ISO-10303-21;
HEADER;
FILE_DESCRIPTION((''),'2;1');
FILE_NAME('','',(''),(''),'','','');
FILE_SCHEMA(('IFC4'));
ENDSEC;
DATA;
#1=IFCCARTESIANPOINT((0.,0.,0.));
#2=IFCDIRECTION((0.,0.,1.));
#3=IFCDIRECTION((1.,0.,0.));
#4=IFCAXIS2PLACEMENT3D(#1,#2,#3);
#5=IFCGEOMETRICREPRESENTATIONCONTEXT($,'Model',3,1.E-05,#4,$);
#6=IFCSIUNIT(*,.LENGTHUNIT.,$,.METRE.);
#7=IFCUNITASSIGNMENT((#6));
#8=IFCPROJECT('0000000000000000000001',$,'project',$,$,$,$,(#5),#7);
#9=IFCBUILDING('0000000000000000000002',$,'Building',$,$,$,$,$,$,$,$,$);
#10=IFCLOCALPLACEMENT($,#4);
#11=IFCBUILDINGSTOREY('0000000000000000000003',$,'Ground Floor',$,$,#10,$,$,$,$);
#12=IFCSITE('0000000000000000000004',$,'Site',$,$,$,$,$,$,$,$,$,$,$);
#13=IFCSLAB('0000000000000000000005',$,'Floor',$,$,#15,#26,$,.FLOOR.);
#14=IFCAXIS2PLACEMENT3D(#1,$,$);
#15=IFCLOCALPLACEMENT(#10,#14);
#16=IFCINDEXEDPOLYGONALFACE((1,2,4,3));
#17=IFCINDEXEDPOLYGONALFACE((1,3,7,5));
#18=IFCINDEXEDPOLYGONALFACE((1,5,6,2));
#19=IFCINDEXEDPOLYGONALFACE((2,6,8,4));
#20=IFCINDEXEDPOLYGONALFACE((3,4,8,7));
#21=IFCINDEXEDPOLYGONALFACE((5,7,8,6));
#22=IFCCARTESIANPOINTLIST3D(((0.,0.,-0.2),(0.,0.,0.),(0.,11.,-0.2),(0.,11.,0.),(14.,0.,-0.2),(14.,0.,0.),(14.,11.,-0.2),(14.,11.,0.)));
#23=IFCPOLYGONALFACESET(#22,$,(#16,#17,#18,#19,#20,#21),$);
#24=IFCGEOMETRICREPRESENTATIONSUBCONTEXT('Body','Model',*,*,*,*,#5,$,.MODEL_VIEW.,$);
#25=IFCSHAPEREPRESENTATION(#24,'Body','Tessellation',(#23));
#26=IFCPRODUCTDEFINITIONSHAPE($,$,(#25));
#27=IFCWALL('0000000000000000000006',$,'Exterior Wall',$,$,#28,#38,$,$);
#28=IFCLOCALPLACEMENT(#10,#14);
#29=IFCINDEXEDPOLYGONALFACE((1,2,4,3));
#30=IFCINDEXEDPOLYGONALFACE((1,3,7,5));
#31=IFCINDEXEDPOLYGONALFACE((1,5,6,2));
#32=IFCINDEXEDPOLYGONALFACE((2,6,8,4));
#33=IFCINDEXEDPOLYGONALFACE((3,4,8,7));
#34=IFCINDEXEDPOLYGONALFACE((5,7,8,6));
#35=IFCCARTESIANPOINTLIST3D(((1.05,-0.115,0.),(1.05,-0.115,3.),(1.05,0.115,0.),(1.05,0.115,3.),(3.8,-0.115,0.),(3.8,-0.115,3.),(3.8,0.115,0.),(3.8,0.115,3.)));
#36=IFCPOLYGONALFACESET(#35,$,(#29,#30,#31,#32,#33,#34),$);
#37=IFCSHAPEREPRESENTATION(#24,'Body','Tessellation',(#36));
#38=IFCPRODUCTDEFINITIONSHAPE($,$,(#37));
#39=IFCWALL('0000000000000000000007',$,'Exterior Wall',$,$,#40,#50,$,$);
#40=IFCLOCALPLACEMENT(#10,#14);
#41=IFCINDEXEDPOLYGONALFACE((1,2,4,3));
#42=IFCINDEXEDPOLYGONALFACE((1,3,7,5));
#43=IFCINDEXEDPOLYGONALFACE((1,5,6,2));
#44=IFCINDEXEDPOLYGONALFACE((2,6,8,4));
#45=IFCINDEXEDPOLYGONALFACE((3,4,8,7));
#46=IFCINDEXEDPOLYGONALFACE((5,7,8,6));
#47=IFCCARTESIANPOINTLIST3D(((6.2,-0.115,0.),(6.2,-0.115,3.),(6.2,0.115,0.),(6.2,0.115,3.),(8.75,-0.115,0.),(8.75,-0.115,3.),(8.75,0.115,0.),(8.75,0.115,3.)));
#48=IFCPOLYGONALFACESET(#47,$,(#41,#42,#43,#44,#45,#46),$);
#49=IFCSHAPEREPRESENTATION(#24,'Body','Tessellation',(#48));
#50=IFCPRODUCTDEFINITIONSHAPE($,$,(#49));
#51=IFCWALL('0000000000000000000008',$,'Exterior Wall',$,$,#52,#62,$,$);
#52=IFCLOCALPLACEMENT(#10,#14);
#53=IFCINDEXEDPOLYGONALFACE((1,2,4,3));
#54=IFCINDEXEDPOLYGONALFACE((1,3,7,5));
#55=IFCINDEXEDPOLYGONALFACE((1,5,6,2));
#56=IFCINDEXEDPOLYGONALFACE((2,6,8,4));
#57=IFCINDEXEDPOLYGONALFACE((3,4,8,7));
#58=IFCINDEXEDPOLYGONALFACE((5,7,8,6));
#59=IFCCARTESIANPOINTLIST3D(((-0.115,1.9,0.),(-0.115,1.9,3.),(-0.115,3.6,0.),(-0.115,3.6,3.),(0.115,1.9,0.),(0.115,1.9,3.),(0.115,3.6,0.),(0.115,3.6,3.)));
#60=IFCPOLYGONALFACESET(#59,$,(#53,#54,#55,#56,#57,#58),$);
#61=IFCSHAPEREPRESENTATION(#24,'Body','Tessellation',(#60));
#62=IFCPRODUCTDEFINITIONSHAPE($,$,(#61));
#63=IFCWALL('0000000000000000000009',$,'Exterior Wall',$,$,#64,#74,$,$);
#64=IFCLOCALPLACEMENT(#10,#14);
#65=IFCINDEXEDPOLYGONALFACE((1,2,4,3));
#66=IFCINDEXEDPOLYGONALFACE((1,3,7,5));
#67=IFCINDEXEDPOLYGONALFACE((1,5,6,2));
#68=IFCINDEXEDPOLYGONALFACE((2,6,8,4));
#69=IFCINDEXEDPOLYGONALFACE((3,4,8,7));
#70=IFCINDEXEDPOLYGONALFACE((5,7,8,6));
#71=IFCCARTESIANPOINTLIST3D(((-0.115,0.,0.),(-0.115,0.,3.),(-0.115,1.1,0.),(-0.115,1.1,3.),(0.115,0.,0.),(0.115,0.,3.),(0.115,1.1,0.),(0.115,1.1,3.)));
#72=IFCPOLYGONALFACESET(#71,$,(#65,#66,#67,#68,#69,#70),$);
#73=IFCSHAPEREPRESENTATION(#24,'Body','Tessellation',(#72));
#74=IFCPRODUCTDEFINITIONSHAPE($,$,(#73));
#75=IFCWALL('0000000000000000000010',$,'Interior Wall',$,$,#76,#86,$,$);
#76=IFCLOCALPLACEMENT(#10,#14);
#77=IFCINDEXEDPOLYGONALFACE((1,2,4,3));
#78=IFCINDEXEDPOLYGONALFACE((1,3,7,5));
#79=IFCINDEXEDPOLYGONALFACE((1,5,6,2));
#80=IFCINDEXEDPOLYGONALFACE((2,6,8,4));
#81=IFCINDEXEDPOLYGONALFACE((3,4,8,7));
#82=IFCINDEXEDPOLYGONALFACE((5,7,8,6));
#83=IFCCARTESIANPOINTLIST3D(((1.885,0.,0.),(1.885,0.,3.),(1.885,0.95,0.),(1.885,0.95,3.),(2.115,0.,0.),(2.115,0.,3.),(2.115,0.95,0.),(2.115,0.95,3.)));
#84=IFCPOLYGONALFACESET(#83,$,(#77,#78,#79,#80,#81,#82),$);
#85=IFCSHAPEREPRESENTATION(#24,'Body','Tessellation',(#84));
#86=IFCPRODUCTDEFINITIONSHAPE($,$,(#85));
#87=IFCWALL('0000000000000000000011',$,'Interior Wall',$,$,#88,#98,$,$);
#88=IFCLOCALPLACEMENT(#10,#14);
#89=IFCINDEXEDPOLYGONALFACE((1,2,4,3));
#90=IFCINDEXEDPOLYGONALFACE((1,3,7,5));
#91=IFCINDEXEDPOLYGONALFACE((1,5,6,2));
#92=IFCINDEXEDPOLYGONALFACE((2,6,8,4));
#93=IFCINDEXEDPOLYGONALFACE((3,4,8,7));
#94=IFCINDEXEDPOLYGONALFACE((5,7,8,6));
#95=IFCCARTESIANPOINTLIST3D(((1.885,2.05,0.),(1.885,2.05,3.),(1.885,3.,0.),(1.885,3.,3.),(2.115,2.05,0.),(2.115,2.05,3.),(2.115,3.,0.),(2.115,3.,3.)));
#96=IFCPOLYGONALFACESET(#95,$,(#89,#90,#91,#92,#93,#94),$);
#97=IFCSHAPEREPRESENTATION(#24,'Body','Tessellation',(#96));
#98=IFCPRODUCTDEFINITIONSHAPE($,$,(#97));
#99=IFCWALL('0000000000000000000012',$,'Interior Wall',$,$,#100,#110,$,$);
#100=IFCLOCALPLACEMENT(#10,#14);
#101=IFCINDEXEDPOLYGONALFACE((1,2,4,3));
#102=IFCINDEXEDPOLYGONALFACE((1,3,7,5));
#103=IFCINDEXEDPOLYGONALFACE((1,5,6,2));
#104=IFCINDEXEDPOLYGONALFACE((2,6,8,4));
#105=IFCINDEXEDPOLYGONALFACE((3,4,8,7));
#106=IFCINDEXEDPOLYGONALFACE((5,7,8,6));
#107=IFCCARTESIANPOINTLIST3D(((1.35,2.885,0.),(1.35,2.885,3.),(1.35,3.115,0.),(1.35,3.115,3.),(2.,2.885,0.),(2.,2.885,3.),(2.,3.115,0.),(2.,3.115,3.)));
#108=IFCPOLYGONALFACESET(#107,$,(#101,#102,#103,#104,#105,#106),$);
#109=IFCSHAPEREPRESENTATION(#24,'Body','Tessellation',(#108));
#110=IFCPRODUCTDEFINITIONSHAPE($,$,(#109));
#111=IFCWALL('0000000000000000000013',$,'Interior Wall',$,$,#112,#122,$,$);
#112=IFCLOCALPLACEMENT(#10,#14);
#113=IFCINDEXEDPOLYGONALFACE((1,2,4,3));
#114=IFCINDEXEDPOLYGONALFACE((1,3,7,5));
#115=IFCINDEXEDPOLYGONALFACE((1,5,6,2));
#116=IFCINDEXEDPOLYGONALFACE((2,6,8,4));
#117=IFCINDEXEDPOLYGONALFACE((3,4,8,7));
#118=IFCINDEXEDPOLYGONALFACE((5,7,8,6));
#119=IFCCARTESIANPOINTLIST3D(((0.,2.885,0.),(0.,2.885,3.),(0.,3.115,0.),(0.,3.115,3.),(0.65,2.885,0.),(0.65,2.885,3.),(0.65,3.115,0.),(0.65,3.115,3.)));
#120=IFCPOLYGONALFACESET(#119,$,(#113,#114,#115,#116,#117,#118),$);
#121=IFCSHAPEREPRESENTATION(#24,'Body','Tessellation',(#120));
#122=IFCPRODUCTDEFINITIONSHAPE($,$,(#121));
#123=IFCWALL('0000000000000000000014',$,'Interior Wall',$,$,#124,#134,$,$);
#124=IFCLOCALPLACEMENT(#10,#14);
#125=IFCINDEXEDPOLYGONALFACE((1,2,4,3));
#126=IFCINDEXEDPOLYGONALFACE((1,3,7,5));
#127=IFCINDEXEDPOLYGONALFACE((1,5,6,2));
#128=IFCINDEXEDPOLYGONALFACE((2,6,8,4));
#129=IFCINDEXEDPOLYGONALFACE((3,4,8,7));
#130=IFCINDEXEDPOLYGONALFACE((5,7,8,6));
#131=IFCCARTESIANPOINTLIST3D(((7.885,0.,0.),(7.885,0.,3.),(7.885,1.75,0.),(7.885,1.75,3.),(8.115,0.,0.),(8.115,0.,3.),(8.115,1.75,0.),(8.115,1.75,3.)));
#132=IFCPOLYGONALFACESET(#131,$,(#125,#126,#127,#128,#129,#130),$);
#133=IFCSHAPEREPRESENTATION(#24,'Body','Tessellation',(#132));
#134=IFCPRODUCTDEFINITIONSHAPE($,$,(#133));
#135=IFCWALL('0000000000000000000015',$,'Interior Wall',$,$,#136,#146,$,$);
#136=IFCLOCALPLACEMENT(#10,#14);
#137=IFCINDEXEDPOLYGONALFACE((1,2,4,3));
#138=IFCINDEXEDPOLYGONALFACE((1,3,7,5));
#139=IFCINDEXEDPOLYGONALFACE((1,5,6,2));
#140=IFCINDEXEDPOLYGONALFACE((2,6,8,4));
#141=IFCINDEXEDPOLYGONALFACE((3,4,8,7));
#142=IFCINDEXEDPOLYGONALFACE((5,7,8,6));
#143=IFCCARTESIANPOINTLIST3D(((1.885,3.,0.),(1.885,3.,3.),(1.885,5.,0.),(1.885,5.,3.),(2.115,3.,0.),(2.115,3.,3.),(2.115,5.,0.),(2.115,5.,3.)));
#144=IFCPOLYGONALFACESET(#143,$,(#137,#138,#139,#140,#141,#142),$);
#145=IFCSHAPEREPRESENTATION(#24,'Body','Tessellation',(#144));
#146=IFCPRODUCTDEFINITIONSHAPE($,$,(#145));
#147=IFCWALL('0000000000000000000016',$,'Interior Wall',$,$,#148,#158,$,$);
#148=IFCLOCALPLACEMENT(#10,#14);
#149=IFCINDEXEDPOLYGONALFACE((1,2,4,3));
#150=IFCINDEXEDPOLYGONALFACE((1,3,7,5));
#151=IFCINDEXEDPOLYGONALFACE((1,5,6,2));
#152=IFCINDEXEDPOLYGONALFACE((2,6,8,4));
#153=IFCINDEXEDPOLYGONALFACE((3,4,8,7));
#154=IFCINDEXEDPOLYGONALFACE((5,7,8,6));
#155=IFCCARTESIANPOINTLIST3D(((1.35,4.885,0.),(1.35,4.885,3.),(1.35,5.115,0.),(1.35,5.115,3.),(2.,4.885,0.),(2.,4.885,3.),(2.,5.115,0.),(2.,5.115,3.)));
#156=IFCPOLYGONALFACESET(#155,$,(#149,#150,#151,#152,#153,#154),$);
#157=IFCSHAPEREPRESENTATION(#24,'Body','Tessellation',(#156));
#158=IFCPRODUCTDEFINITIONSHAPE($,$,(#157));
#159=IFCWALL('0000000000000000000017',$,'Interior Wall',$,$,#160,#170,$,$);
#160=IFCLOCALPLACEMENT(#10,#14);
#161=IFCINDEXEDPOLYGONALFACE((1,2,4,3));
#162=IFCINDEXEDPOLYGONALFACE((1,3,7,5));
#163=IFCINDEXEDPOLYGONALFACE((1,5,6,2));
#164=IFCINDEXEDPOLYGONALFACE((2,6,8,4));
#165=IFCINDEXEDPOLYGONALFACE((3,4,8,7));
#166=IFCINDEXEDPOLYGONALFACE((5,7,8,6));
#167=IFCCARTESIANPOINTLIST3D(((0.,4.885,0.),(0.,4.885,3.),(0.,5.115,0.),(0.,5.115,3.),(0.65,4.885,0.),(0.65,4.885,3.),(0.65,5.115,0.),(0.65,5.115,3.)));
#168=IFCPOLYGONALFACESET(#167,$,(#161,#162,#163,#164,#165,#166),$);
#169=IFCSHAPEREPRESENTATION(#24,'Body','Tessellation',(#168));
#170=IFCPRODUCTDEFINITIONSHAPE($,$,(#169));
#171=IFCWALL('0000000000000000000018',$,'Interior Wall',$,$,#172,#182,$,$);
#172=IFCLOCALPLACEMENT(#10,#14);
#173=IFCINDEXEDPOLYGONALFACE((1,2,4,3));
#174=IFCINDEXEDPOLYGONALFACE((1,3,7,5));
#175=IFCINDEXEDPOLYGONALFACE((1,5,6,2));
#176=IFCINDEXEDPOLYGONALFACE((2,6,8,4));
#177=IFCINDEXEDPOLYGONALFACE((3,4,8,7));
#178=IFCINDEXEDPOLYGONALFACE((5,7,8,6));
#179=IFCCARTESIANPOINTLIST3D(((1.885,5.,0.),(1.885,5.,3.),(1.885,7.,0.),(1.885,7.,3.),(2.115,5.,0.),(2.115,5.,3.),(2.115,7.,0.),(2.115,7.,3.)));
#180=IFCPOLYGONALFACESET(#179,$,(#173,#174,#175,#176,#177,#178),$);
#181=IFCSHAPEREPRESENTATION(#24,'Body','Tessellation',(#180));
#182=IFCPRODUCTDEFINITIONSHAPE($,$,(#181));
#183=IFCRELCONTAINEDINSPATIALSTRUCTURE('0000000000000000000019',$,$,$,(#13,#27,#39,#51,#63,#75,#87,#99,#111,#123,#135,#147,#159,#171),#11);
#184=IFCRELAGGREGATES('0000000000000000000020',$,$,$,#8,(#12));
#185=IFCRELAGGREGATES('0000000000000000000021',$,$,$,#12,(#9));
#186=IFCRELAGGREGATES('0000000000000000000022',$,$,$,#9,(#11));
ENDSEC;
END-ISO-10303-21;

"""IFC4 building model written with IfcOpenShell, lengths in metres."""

from ifc_helpers import new_model, si_unit, frame, origin_with_axes, place, context, subcontext, project, spatial, indexed_curve, outline, extrude, element, save


model = new_model("IFC4")

# Units and contexts
model_context = context("Model", 3, precision=1e-05, world=origin_with_axes())
body_context = subcontext(model_context, "Body", "Model", "MODEL_VIEW")
ifc_project = project(units=[si_unit("LENGTHUNIT", "METRE")], contexts=[model_context])

# Site, building, storey
site = spatial("IfcSite", under=ifc_project, Name="Site")
building = spatial("IfcBuilding", under=site, Name="Building")
storey_placement = place(None, origin_with_axes())
storey = spatial("IfcBuildingStorey", under=building, at=storey_placement, Name="Ground Floor")

# Slab
slab_placement = place(storey_placement, frame((0.0, 0.0, -0.2), z_axis=(0.0, 0.0, 1.0), x_axis=(1.0, 0.0, 0.0)))
element("IfcSlab", 1, at=slab_placement, inside=storey, Name="Floor", PredefinedType="FLOOR", context=body_context, shape_type="SweptSolid", body=[
    extrude(outline(indexed_curve([(0.0, 0.0), (14.0, 0.0), (14.0, 11.0), (0.0, 11.0)])), None, (0.0, 0.0, 1.0), 0.2),
])

# Walls
wall_1_placement = place(storey_placement, frame((1.05, 0.0, 0.0), z_axis=(0.0, 0.0, 1.0), x_axis=(1.0, 0.0, 0.0)))
element("IfcWall", 2, at=wall_1_placement, inside=storey, Name="Exterior Wall", context=body_context, shape_type="SweptSolid", body=[
    extrude(outline(indexed_curve([(0.0, 0.0), (0.0, 0.23), (2.75, 0.23), (2.75, 0.0), (0.0, 0.0)], self_intersect=False)), frame((0.0, -0.115, 0.0), z_axis=(0.0, 0.0, 1.0), x_axis=(1.0, 0.0, 0.0)), (0.0, 0.0, 1.0), 3.0),
])
wall_2_placement = place(storey_placement, frame((6.2, 0.0, 0.0), z_axis=(0.0, 0.0, 1.0), x_axis=(1.0, 0.0, 0.0)))
element("IfcWall", 3, at=wall_2_placement, inside=storey, Name="Exterior Wall", context=body_context, shape_type="SweptSolid", body=[
    extrude(outline(indexed_curve([(0.0, 0.0), (0.0, 0.23), (2.55, 0.23), (2.55, 0.0), (0.0, 0.0)], self_intersect=False)), frame((0.0, -0.115, 0.0), z_axis=(0.0, 0.0, 1.0), x_axis=(1.0, 0.0, 0.0)), (0.0, 0.0, 1.0), 3.0),
])
wall_3_placement = place(storey_placement, frame((0.0, 3.6, 0.0), z_axis=(0.0, 0.0, 1.0), x_axis=(0.0, -1.0, 0.0)))
element("IfcWall", 4, at=wall_3_placement, inside=storey, Name="Exterior Wall", context=body_context, shape_type="SweptSolid", body=[
    extrude(outline(indexed_curve([(0.0, 0.0), (0.0, 0.23), (1.7, 0.23), (1.7, 0.0), (0.0, 0.0)], self_intersect=False)), frame((0.0, -0.115, 0.0), z_axis=(0.0, 0.0, 1.0), x_axis=(1.0, 0.0, 0.0)), (0.0, 0.0, 1.0), 3.0),
])
wall_4_placement = place(storey_placement, frame((0.0, 1.1, 0.0), z_axis=(0.0, 0.0, 1.0), x_axis=(0.0, -1.0, 0.0)))
element("IfcWall", 5, at=wall_4_placement, inside=storey, Name="Exterior Wall", context=body_context, shape_type="SweptSolid", body=[
    extrude(outline(indexed_curve([(0.0, 0.0), (0.0, 0.23), (1.1, 0.23), (1.1, 0.0), (0.0, 0.0)], self_intersect=False)), frame((0.0, -0.115, 0.0), z_axis=(0.0, 0.0, 1.0), x_axis=(1.0, 0.0, 0.0)), (0.0, 0.0, 1.0), 3.0),
])
wall_5_placement = place(storey_placement, frame((2.0, 0.0, 0.0), z_axis=(0.0, 0.0, 1.0), x_axis=(0.0, 1.0, 0.0)))
element("IfcWall", 6, at=wall_5_placement, inside=storey, Name="Interior Wall", context=body_context, shape_type="SweptSolid", body=[
    extrude(outline(indexed_curve([(0.0, 0.0), (0.0, 0.23), (0.95, 0.23), (0.95, 0.0), (0.0, 0.0)], self_intersect=False)), frame((0.0, -0.115, 0.0), z_axis=(0.0, 0.0, 1.0), x_axis=(1.0, 0.0, 0.0)), (0.0, 0.0, 1.0), 3.0),
])
wall_6_placement = place(storey_placement, frame((2.0, 2.05, 0.0), z_axis=(0.0, 0.0, 1.0), x_axis=(0.0, 1.0, 0.0)))
element("IfcWall", 7, at=wall_6_placement, inside=storey, Name="Interior Wall", context=body_context, shape_type="SweptSolid", body=[
    extrude(outline(indexed_curve([(0.0, 0.0), (0.0, 0.23), (0.95, 0.23), (0.95, 0.0), (0.0, 0.0)], self_intersect=False)), frame((0.0, -0.115, 0.0), z_axis=(0.0, 0.0, 1.0), x_axis=(1.0, 0.0, 0.0)), (0.0, 0.0, 1.0), 3.0),
])
for number, where, z_axis, x_axis, name in (
    (8, (2.0, 3.0, 0.0), (0.0, 0.0, 1.0), (-1.0, 0.0, 0.0), "Interior Wall"),
    (9, (0.65, 3.0, 0.0), (0.0, 0.0, 1.0), (-1.0, 0.0, 0.0), "Interior Wall"),
):
    element("IfcWall", number, at=place(storey_placement, frame(where, z_axis=z_axis, x_axis=x_axis)), inside=storey, Name=name, context=body_context, shape_type="SweptSolid", body=[
        extrude(outline(indexed_curve([(0.0, 0.0), (0.0, 0.23), (0.65, 0.23), (0.65, 0.0), (0.0, 0.0)], self_intersect=False)), frame((0.0, -0.115, 0.0), z_axis=(0.0, 0.0, 1.0), x_axis=(1.0, 0.0, 0.0)), (0.0, 0.0, 1.0), 3.0),
    ])
wall_7_placement = place(storey_placement, frame((8.0, 0.0, 0.0), z_axis=(0.0, 0.0, 1.0), x_axis=(0.0, 1.0, 0.0)))
element("IfcWall", 10, at=wall_7_placement, inside=storey, Name="Interior Wall", context=body_context, shape_type="SweptSolid", body=[
    extrude(outline(indexed_curve([(0.0, 0.0), (0.0, 0.23), (1.75, 0.23), (1.75, 0.0), (0.0, 0.0)], self_intersect=False)), frame((0.0, -0.115, 0.0), z_axis=(0.0, 0.0, 1.0), x_axis=(1.0, 0.0, 0.0)), (0.0, 0.0, 1.0), 3.0),
])
wall_8_placement = place(storey_placement, frame((2.0, 5.0, 0.0), z_axis=(0.0, 0.0, 1.0), x_axis=(0.0, -1.0, 0.0)))
element("IfcWall", 11, at=wall_8_placement, inside=storey, Name="Interior Wall", context=body_context, shape_type="SweptSolid", body=[
    extrude(outline(indexed_curve([(0.0, 0.0), (0.0, 0.23), (2.0, 0.23), (2.0, 0.0), (0.0, 0.0)], self_intersect=False)), frame((0.0, -0.115, 0.0), z_axis=(0.0, 0.0, 1.0), x_axis=(1.0, 0.0, 0.0)), (0.0, 0.0, 1.0), 3.0),
])
for number, where, z_axis, x_axis, name in (
    (12, (2.0, 5.0, 0.0), (0.0, 0.0, 1.0), (-1.0, 0.0, 0.0), "Interior Wall"),
    (13, (0.65, 5.0, 0.0), (0.0, 0.0, 1.0), (-1.0, 0.0, 0.0), "Interior Wall"),
):
    element("IfcWall", number, at=place(storey_placement, frame(where, z_axis=z_axis, x_axis=x_axis)), inside=storey, Name=name, context=body_context, shape_type="SweptSolid", body=[
        extrude(outline(indexed_curve([(0.0, 0.0), (0.0, 0.23), (0.65, 0.23), (0.65, 0.0), (0.0, 0.0)], self_intersect=False)), frame((0.0, -0.115, 0.0), z_axis=(0.0, 0.0, 1.0), x_axis=(1.0, 0.0, 0.0)), (0.0, 0.0, 1.0), 3.0),
    ])
wall_9_placement = place(storey_placement, frame((2.0, 5.0, 0.0), z_axis=(0.0, 0.0, 1.0), x_axis=(0.0, 1.0, 0.0)))
element("IfcWall", 14, at=wall_9_placement, inside=storey, Name="Interior Wall", context=body_context, shape_type="SweptSolid", body=[
    extrude(outline(indexed_curve([(0.0, 0.0), (0.0, 0.23), (2.0, 0.23), (2.0, 0.0), (0.0, 0.0)], self_intersect=False)), frame((0.0, -0.115, 0.0), z_axis=(0.0, 0.0, 1.0), x_axis=(1.0, 0.0, 0.0)), (0.0, 0.0, 1.0), 3.0),
])

save(model, "model.ifc")
